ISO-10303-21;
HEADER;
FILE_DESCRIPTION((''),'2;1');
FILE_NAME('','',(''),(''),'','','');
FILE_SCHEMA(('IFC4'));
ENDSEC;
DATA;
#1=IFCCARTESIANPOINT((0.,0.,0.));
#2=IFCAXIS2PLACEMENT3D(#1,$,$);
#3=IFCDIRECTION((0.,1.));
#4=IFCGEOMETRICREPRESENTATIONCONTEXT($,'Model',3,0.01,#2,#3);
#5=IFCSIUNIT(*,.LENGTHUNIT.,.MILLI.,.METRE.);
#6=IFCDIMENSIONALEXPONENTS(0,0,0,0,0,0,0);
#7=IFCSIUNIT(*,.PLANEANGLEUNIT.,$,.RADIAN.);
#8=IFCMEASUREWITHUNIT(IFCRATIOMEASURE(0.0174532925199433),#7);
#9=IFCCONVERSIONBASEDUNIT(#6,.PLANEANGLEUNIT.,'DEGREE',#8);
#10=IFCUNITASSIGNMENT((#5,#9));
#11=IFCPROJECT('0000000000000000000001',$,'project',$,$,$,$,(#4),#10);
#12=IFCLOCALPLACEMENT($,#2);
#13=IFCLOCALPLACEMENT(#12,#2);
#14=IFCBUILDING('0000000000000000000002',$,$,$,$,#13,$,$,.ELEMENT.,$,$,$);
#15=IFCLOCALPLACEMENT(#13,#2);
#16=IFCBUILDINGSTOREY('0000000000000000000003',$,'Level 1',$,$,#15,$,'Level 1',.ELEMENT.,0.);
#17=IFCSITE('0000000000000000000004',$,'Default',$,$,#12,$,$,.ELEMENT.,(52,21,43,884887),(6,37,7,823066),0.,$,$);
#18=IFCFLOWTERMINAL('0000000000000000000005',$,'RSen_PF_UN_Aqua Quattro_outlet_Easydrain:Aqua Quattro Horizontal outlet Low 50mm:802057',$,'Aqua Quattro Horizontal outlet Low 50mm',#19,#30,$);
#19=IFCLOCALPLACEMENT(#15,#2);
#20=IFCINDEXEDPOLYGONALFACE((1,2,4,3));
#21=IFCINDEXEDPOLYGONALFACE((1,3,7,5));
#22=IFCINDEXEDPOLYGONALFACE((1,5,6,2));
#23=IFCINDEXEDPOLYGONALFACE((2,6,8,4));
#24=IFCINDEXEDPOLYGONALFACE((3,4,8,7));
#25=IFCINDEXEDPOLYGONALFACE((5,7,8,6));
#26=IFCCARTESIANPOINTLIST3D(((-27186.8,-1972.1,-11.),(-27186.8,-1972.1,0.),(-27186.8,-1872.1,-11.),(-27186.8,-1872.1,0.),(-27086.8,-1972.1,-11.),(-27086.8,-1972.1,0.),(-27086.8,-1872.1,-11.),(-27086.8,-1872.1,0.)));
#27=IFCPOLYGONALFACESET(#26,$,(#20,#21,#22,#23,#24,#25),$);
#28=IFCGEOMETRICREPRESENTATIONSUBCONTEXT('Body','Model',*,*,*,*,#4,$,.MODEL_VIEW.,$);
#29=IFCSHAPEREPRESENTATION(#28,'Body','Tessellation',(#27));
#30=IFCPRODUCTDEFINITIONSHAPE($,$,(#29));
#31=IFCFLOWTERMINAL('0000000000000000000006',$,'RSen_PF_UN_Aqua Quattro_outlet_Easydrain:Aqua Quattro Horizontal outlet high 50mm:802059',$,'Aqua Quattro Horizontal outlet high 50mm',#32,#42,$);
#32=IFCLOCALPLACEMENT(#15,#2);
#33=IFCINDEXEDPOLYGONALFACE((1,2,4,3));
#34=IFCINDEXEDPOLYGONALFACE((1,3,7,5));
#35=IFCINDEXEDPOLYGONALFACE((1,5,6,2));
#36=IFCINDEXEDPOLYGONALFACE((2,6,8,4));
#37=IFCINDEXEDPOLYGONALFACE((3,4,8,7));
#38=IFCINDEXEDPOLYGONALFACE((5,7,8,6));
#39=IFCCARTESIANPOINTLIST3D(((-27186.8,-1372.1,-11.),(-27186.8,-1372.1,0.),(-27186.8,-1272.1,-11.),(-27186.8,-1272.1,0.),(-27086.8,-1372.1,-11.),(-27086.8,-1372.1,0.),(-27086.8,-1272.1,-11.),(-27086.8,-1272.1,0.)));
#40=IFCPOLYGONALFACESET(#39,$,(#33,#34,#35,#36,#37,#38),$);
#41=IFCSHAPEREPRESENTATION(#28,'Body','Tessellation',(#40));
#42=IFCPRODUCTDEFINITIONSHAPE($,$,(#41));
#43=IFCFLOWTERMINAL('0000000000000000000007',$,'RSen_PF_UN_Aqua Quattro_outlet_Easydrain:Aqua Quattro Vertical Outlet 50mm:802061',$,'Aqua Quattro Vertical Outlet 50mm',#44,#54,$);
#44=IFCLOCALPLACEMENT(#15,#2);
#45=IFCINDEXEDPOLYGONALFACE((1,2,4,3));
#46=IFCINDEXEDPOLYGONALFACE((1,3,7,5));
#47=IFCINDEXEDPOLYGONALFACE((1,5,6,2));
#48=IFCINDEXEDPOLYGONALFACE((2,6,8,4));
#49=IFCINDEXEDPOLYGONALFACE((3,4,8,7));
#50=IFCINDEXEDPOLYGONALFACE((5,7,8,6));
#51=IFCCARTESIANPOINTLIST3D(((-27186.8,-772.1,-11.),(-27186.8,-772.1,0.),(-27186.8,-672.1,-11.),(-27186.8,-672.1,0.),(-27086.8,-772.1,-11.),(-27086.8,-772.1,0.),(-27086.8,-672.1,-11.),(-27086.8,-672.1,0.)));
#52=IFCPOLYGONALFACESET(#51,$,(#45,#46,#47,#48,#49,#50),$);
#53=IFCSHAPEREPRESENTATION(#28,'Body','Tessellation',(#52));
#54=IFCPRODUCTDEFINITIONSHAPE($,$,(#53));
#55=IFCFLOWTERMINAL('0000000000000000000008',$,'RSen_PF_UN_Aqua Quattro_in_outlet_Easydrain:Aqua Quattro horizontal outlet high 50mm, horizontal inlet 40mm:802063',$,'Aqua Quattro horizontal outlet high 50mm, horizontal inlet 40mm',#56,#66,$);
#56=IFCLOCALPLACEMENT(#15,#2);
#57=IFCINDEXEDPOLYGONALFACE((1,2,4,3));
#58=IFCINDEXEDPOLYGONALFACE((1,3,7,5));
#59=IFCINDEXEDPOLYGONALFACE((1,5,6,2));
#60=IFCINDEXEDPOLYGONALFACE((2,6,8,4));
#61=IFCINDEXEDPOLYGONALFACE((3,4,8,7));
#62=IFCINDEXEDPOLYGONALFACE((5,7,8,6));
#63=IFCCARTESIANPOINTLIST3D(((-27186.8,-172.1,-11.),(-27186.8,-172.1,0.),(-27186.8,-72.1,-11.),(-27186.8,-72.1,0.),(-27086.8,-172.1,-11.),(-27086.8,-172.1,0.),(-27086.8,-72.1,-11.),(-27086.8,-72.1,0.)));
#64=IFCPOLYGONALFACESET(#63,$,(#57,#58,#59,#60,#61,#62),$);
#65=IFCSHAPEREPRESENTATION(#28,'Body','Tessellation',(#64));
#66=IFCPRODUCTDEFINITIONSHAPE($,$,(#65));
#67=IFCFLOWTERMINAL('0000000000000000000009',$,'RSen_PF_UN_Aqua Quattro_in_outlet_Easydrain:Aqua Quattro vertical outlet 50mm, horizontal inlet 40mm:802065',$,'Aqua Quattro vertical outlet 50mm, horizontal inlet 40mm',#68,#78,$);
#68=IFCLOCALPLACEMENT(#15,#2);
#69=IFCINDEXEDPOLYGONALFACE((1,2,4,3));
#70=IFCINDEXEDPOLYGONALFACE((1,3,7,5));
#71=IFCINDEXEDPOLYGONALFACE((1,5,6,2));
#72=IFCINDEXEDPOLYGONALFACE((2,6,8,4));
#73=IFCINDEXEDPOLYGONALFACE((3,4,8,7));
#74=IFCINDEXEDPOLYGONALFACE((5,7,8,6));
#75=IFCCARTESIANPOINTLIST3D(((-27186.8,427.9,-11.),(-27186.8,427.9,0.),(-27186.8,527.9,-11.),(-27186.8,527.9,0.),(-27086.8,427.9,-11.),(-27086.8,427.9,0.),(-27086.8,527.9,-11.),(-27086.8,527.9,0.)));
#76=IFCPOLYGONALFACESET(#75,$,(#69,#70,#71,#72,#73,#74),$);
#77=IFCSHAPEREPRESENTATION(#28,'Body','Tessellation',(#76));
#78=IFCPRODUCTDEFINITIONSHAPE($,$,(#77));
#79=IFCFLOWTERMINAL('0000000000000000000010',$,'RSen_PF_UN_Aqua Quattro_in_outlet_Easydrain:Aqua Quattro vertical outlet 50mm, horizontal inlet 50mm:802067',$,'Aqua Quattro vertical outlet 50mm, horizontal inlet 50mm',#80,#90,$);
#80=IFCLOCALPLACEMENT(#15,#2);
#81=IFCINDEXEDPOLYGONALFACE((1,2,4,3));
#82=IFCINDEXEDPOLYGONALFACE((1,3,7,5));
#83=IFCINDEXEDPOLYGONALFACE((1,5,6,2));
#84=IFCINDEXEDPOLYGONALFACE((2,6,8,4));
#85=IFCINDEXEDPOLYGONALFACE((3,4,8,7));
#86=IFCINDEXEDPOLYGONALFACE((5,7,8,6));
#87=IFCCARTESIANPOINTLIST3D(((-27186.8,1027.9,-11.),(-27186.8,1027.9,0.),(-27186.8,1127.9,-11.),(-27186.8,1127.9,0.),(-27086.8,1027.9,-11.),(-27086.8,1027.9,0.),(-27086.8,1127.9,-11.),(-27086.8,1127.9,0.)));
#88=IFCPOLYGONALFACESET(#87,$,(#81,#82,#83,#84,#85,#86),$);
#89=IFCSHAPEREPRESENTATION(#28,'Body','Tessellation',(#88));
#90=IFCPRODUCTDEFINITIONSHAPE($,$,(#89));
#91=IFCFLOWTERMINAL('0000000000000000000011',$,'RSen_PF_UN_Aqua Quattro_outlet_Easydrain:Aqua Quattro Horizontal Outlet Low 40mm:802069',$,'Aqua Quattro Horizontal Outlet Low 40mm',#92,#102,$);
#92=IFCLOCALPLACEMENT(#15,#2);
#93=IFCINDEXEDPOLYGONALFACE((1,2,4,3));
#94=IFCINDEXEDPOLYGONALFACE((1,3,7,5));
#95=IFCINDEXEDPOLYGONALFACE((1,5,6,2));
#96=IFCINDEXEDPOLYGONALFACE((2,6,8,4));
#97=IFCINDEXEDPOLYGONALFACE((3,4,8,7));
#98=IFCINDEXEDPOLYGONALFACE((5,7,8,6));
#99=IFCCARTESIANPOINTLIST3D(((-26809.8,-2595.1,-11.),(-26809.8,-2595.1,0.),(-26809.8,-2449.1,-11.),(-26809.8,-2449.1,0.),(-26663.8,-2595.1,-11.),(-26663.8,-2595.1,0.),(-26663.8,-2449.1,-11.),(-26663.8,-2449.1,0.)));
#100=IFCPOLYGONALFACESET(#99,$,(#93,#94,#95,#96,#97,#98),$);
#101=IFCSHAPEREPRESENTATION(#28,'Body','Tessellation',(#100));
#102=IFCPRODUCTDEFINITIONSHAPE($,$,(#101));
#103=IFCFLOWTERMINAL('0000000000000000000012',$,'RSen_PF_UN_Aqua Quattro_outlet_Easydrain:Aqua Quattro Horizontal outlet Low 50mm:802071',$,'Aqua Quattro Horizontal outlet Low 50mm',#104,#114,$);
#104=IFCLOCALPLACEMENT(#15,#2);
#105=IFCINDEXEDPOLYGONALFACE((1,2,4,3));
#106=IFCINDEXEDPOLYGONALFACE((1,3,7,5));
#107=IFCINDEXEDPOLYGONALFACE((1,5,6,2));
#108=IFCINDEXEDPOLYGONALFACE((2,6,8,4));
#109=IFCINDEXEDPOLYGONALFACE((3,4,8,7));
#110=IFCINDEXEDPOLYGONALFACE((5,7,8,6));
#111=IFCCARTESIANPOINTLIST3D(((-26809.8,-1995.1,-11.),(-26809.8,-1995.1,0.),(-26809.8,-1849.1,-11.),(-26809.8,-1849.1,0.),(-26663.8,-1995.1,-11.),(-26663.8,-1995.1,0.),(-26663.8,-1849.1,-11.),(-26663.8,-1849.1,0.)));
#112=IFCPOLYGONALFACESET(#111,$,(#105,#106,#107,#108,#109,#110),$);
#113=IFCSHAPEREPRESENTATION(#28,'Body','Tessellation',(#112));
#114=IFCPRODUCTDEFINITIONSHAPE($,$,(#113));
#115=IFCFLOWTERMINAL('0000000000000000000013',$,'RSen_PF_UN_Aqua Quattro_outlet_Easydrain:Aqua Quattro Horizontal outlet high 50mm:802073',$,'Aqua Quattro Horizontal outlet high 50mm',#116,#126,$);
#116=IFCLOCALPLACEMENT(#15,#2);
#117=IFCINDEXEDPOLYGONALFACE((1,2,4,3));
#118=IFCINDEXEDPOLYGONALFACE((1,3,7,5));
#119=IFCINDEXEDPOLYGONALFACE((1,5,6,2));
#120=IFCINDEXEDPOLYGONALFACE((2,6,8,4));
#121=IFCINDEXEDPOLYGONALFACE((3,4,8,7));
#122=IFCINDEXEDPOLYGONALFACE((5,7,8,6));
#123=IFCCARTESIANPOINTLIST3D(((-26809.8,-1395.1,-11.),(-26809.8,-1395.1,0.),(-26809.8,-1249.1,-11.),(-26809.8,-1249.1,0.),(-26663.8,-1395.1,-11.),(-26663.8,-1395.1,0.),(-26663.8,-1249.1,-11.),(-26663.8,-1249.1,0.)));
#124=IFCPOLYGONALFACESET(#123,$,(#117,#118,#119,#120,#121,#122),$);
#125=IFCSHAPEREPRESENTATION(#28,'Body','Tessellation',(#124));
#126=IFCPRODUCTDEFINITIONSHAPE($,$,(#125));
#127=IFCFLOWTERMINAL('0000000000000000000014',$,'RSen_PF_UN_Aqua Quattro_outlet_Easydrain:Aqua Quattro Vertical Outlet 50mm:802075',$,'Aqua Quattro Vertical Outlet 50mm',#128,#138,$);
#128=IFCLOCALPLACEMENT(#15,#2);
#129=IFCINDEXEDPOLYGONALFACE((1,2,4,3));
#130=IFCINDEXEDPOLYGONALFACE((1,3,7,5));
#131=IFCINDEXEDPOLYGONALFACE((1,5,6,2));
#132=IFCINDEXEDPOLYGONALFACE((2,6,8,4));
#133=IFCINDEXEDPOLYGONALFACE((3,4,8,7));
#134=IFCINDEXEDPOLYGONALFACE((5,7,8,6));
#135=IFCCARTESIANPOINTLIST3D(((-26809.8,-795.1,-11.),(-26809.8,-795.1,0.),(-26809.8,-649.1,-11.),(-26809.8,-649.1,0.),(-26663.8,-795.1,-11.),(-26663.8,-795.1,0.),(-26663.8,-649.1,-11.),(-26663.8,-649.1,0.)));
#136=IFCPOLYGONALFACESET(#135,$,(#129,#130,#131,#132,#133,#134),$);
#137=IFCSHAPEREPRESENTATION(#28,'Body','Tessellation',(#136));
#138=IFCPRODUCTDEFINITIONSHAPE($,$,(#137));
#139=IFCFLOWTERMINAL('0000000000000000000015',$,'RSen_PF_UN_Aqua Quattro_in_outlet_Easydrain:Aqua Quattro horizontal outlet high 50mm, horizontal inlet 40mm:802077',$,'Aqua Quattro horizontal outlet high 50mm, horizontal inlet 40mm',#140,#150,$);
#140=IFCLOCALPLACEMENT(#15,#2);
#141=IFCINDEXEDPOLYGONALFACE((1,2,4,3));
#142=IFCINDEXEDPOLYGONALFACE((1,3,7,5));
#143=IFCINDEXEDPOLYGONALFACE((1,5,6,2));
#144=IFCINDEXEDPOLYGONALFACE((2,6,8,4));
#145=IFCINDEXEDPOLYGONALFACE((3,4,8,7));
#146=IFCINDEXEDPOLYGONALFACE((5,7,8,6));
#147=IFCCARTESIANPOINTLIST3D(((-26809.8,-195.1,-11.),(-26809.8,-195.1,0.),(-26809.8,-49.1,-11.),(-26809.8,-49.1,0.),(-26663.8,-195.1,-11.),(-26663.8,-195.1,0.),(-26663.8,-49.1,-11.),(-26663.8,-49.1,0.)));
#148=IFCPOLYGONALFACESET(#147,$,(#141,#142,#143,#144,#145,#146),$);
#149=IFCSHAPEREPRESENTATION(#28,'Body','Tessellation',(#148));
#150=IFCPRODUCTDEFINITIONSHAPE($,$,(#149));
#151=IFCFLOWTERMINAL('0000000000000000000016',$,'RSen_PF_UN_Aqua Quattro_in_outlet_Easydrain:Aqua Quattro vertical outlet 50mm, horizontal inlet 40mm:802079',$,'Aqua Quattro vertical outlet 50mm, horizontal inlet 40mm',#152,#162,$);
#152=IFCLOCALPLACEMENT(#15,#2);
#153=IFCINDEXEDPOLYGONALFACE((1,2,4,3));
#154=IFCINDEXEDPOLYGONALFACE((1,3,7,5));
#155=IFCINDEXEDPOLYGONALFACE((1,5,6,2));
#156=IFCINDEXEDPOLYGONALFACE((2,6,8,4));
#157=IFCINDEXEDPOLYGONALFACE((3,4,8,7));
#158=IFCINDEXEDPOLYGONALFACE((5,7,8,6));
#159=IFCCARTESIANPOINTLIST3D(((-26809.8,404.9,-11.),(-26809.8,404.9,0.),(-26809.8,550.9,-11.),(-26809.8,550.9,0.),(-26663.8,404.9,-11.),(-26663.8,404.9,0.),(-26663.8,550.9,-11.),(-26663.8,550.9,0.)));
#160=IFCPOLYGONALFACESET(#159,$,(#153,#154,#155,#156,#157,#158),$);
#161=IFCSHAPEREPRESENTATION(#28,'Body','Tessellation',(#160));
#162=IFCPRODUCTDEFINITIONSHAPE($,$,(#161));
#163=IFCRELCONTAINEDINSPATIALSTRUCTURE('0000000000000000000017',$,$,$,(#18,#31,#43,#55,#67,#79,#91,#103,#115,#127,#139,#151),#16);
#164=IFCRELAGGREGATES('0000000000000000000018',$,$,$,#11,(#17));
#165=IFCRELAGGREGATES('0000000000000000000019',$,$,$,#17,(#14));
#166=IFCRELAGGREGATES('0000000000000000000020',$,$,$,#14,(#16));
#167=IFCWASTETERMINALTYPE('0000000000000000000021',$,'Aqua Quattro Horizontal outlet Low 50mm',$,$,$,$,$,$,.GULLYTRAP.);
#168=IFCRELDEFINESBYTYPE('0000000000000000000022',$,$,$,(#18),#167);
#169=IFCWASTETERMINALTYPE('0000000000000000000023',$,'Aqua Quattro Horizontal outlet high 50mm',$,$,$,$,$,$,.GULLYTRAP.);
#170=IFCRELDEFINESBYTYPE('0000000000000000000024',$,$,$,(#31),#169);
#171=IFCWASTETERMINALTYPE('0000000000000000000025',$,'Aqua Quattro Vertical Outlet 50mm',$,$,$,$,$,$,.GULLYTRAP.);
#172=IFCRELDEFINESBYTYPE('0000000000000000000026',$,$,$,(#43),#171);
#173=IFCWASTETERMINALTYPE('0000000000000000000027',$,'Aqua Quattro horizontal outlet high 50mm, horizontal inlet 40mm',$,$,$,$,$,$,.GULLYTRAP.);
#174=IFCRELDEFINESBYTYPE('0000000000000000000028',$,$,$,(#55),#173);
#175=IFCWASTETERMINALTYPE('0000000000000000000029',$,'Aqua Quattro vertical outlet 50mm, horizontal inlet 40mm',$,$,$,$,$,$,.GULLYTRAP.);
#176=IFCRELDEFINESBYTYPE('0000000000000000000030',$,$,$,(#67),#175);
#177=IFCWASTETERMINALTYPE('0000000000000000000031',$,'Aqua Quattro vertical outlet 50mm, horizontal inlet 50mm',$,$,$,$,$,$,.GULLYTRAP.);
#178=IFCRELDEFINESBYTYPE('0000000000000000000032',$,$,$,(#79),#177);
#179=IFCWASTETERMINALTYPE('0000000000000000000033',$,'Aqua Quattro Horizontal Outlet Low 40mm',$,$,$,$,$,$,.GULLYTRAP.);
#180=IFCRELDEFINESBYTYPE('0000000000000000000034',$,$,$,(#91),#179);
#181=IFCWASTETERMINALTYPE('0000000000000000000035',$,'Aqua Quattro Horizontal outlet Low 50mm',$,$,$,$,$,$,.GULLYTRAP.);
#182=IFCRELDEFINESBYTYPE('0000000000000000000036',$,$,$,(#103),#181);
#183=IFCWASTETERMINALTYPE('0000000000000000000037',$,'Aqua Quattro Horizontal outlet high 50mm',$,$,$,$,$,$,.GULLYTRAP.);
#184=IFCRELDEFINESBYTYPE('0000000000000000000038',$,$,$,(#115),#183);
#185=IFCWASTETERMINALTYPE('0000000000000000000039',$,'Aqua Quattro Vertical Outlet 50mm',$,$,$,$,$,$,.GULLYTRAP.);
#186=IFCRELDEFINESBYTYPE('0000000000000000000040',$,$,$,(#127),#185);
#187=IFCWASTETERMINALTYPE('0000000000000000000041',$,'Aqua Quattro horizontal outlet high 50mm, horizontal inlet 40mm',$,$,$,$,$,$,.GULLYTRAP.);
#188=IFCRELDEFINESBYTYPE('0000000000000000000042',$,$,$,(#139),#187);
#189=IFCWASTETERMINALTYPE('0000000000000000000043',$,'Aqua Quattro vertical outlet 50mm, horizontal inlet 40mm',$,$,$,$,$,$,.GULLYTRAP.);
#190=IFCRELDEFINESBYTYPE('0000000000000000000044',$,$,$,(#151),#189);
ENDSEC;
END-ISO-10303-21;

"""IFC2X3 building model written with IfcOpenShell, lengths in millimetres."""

from ifc_helpers import new_model, entity, si_unit, converted_unit, direction, frame, origin, origin_2d_with_axis, place, context, subcontext, project, spatial, rectangle, extrude, source, transform, mapped, type_object, type_shapes, element, save


model = new_model("IFC2X3")

# Units and contexts
model_context = context("Model", 3, precision=0.01, world=origin(), true_north=direction((0.0, 1.0)))
body_context = subcontext(model_context, "Body", "Model", "MODEL_VIEW")
ifc_project = project(units=[si_unit("LENGTHUNIT", "METRE", prefix="MILLI"), converted_unit("PLANEANGLEUNIT", "DEGREE", entity("IfcRatioMeasure", 0.0174532925199433), si_unit("PLANEANGLEUNIT", "RADIAN"), dimensions=[0, 0, 0, 0, 0, 0, 0])], contexts=[model_context])

# Site, building, storey
site_placement = place(None, origin())
site = spatial("IfcSite", under=ifc_project, at=site_placement, Name="Default", CompositionType="ELEMENT", RefLatitude=(52, 21, 43, 884887), RefLongitude=(6, 37, 7, 823066), RefElevation=0.0)
building_placement = place(site_placement, origin())
building = spatial("IfcBuilding", under=site, at=building_placement, CompositionType="ELEMENT")
storey_placement = place(building_placement, origin())
storey = spatial("IfcBuildingStorey", under=building, at=storey_placement, Name="Level 1", LongName="Level 1", CompositionType="ELEMENT", Elevation=0.0)

# Flow terminals
waste_terminal_type_1 = type_object("IfcWasteTerminalType", Name="Aqua Quattro Horizontal outlet Low 50mm", PredefinedType="GULLYTRAP")
shared_shape_1 = source(origin(), body_context, "Body", "SweptSolid", [
    extrude(rectangle(XDim=100.0, YDim=100.0, at=origin_2d_with_axis()), frame((0.0, 0.0, -11.0), z_axis=(0.0, 0.0, 1.0), x_axis=(-1.0, 0.0, 0.0)), (0.0, 0.0, 1.0), 11.0),
])
type_shapes(waste_terminal_type_1, [shared_shape_1])
flow_terminal_1_placement = place(storey_placement, frame((-27136.8, -1922.1, 0.0)))
element("IfcFlowTerminal", 1, at=flow_terminal_1_placement, inside=storey, type_object=waste_terminal_type_1, Name="RSen_PF_UN_Aqua Quattro_outlet_Easydrain:Aqua Quattro Horizontal outlet Low 50mm:802057", ObjectType="Aqua Quattro Horizontal outlet Low 50mm", context=body_context, shape_type="MappedRepresentation", body=[
    mapped(shared_shape_1, transform((0.0, 0.0, 0.0), scale=1.0)),
])
waste_terminal_type_2 = type_object("IfcWasteTerminalType", Name="Aqua Quattro Horizontal outlet high 50mm", PredefinedType="GULLYTRAP")
shared_shape_2 = source(origin(), body_context, "Body", "SweptSolid", [
    extrude(rectangle(XDim=100.0, YDim=100.0, at=origin_2d_with_axis()), frame((0.0, 0.0, -11.0), z_axis=(0.0, 0.0, 1.0), x_axis=(-1.0, 0.0, 0.0)), (0.0, 0.0, 1.0), 11.0),
])
type_shapes(waste_terminal_type_2, [shared_shape_2])
flow_terminal_2_placement = place(storey_placement, frame((-27136.8, -1322.1, 0.0)))
element("IfcFlowTerminal", 2, at=flow_terminal_2_placement, inside=storey, type_object=waste_terminal_type_2, Name="RSen_PF_UN_Aqua Quattro_outlet_Easydrain:Aqua Quattro Horizontal outlet high 50mm:802059", ObjectType="Aqua Quattro Horizontal outlet high 50mm", context=body_context, shape_type="MappedRepresentation", body=[
    mapped(shared_shape_2, transform((0.0, 0.0, 0.0), scale=1.0)),
])
waste_terminal_type_3 = type_object("IfcWasteTerminalType", Name="Aqua Quattro Vertical Outlet 50mm", PredefinedType="GULLYTRAP")
shared_shape_3 = source(origin(), body_context, "Body", "SweptSolid", [
    extrude(rectangle(XDim=100.0, YDim=100.0, at=origin_2d_with_axis()), frame((0.0, 0.0, -11.0), z_axis=(0.0, 0.0, 1.0), x_axis=(-1.0, 0.0, 0.0)), (0.0, 0.0, 1.0), 11.0),
])
type_shapes(waste_terminal_type_3, [shared_shape_3])
flow_terminal_3_placement = place(storey_placement, frame((-27136.8, -722.1, 0.0)))
element("IfcFlowTerminal", 3, at=flow_terminal_3_placement, inside=storey, type_object=waste_terminal_type_3, Name="RSen_PF_UN_Aqua Quattro_outlet_Easydrain:Aqua Quattro Vertical Outlet 50mm:802061", ObjectType="Aqua Quattro Vertical Outlet 50mm", context=body_context, shape_type="MappedRepresentation", body=[
    mapped(shared_shape_3, transform((0.0, 0.0, 0.0), scale=1.0)),
])
waste_terminal_type_4 = type_object("IfcWasteTerminalType", Name="Aqua Quattro horizontal outlet high 50mm, horizontal inlet 40mm", PredefinedType="GULLYTRAP")
shared_shape_4 = source(origin(), body_context, "Body", "SweptSolid", [
    extrude(rectangle(XDim=100.0, YDim=100.0, at=origin_2d_with_axis()), frame((0.0, 0.0, -11.0), z_axis=(0.0, 0.0, 1.0), x_axis=(-1.0, 0.0, 0.0)), (0.0, 0.0, 1.0), 11.0),
])
type_shapes(waste_terminal_type_4, [shared_shape_4])
flow_terminal_4_placement = place(storey_placement, frame((-27136.8, -122.1, 0.0)))
element("IfcFlowTerminal", 4, at=flow_terminal_4_placement, inside=storey, type_object=waste_terminal_type_4, Name="RSen_PF_UN_Aqua Quattro_in_outlet_Easydrain:Aqua Quattro horizontal outlet high 50mm, horizontal inlet 40mm:802063", ObjectType="Aqua Quattro horizontal outlet high 50mm, horizontal inlet 40mm", context=body_context, shape_type="MappedRepresentation", body=[
    mapped(shared_shape_4, transform((0.0, 0.0, 0.0), scale=1.0)),
])
waste_terminal_type_5 = type_object("IfcWasteTerminalType", Name="Aqua Quattro vertical outlet 50mm, horizontal inlet 40mm", PredefinedType="GULLYTRAP")
shared_shape_5 = source(origin(), body_context, "Body", "SweptSolid", [
    extrude(rectangle(XDim=100.0, YDim=100.0, at=origin_2d_with_axis()), frame((0.0, 0.0, -11.0), z_axis=(0.0, 0.0, 1.0), x_axis=(-1.0, 0.0, 0.0)), (0.0, 0.0, 1.0), 11.0),
])
type_shapes(waste_terminal_type_5, [shared_shape_5])
flow_terminal_5_placement = place(storey_placement, frame((-27136.8, 477.9, 0.0)))
element("IfcFlowTerminal", 5, at=flow_terminal_5_placement, inside=storey, type_object=waste_terminal_type_5, Name="RSen_PF_UN_Aqua Quattro_in_outlet_Easydrain:Aqua Quattro vertical outlet 50mm, horizontal inlet 40mm:802065", ObjectType="Aqua Quattro vertical outlet 50mm, horizontal inlet 40mm", context=body_context, shape_type="MappedRepresentation", body=[
    mapped(shared_shape_5, transform((0.0, 0.0, 0.0), scale=1.0)),
])
waste_terminal_type_6 = type_object("IfcWasteTerminalType", Name="Aqua Quattro vertical outlet 50mm, horizontal inlet 50mm", PredefinedType="GULLYTRAP")
shared_shape_6 = source(origin(), body_context, "Body", "SweptSolid", [
    extrude(rectangle(XDim=100.0, YDim=100.0, at=origin_2d_with_axis()), frame((0.0, 0.0, -11.0), z_axis=(0.0, 0.0, 1.0), x_axis=(-1.0, 0.0, 0.0)), (0.0, 0.0, 1.0), 11.0),
])
type_shapes(waste_terminal_type_6, [shared_shape_6])
flow_terminal_6_placement = place(storey_placement, frame((-27136.8, 1077.9, 0.0)))
element("IfcFlowTerminal", 6, at=flow_terminal_6_placement, inside=storey, type_object=waste_terminal_type_6, Name="RSen_PF_UN_Aqua Quattro_in_outlet_Easydrain:Aqua Quattro vertical outlet 50mm, horizontal inlet 50mm:802067", ObjectType="Aqua Quattro vertical outlet 50mm, horizontal inlet 50mm", context=body_context, shape_type="MappedRepresentation", body=[
    mapped(shared_shape_6, transform((0.0, 0.0, 0.0), scale=1.0)),
])
waste_terminal_type_7 = type_object("IfcWasteTerminalType", Name="Aqua Quattro Horizontal Outlet Low 40mm", PredefinedType="GULLYTRAP")
shared_shape_7 = source(origin(), body_context, "Body", "SweptSolid", [
    extrude(rectangle(XDim=146.0, YDim=146.0, at=origin_2d_with_axis()), frame((0.0, 0.0, -11.0), z_axis=(0.0, 0.0, 1.0), x_axis=(-1.0, 0.0, 0.0)), (0.0, 0.0, 1.0), 11.0),
])
type_shapes(waste_terminal_type_7, [shared_shape_7])
flow_terminal_7_placement = place(storey_placement, frame((-26736.8, -2522.1, 0.0)))
element("IfcFlowTerminal", 7, at=flow_terminal_7_placement, inside=storey, type_object=waste_terminal_type_7, Name="RSen_PF_UN_Aqua Quattro_outlet_Easydrain:Aqua Quattro Horizontal Outlet Low 40mm:802069", ObjectType="Aqua Quattro Horizontal Outlet Low 40mm", context=body_context, shape_type="MappedRepresentation", body=[
    mapped(shared_shape_7, transform((0.0, 0.0, 0.0), scale=1.0)),
])
waste_terminal_type_8 = type_object("IfcWasteTerminalType", Name="Aqua Quattro Horizontal outlet Low 50mm", PredefinedType="GULLYTRAP")
shared_shape_8 = source(origin(), body_context, "Body", "SweptSolid", [
    extrude(rectangle(XDim=146.0, YDim=146.0, at=origin_2d_with_axis()), frame((0.0, 0.0, -11.0), z_axis=(0.0, 0.0, 1.0), x_axis=(-1.0, 0.0, 0.0)), (0.0, 0.0, 1.0), 11.0),
])
type_shapes(waste_terminal_type_8, [shared_shape_8])
flow_terminal_8_placement = place(storey_placement, frame((-26736.8, -1922.1, 0.0)))
element("IfcFlowTerminal", 8, at=flow_terminal_8_placement, inside=storey, type_object=waste_terminal_type_8, Name="RSen_PF_UN_Aqua Quattro_outlet_Easydrain:Aqua Quattro Horizontal outlet Low 50mm:802071", ObjectType="Aqua Quattro Horizontal outlet Low 50mm", context=body_context, shape_type="MappedRepresentation", body=[
    mapped(shared_shape_8, transform((0.0, 0.0, 0.0), scale=1.0)),
])
waste_terminal_type_9 = type_object("IfcWasteTerminalType", Name="Aqua Quattro Horizontal outlet high 50mm", PredefinedType="GULLYTRAP")
shared_shape_9 = source(origin(), body_context, "Body", "SweptSolid", [
    extrude(rectangle(XDim=146.0, YDim=146.0, at=origin_2d_with_axis()), frame((0.0, 0.0, -11.0), z_axis=(0.0, 0.0, 1.0), x_axis=(-1.0, 0.0, 0.0)), (0.0, 0.0, 1.0), 11.0),
])
type_shapes(waste_terminal_type_9, [shared_shape_9])
flow_terminal_9_placement = place(storey_placement, frame((-26736.8, -1322.1, 0.0)))
element("IfcFlowTerminal", 9, at=flow_terminal_9_placement, inside=storey, type_object=waste_terminal_type_9, Name="RSen_PF_UN_Aqua Quattro_outlet_Easydrain:Aqua Quattro Horizontal outlet high 50mm:802073", ObjectType="Aqua Quattro Horizontal outlet high 50mm", context=body_context, shape_type="MappedRepresentation", body=[
    mapped(shared_shape_9, transform((0.0, 0.0, 0.0), scale=1.0)),
])
waste_terminal_type_10 = type_object("IfcWasteTerminalType", Name="Aqua Quattro Vertical Outlet 50mm", PredefinedType="GULLYTRAP")
shared_shape_10 = source(origin(), body_context, "Body", "SweptSolid", [
    extrude(rectangle(XDim=146.0, YDim=146.0, at=origin_2d_with_axis()), frame((0.0, 0.0, -11.0), z_axis=(0.0, 0.0, 1.0), x_axis=(-1.0, 0.0, 0.0)), (0.0, 0.0, 1.0), 11.0),
])
type_shapes(waste_terminal_type_10, [shared_shape_10])
flow_terminal_10_placement = place(storey_placement, frame((-26736.8, -722.1, 0.0)))
element("IfcFlowTerminal", 10, at=flow_terminal_10_placement, inside=storey, type_object=waste_terminal_type_10, Name="RSen_PF_UN_Aqua Quattro_outlet_Easydrain:Aqua Quattro Vertical Outlet 50mm:802075", ObjectType="Aqua Quattro Vertical Outlet 50mm", context=body_context, shape_type="MappedRepresentation", body=[
    mapped(shared_shape_10, transform((0.0, 0.0, 0.0), scale=1.0)),
])
waste_terminal_type_11 = type_object("IfcWasteTerminalType", Name="Aqua Quattro horizontal outlet high 50mm, horizontal inlet 40mm", PredefinedType="GULLYTRAP")
shared_shape_11 = source(origin(), body_context, "Body", "SweptSolid", [
    extrude(rectangle(XDim=146.0, YDim=146.0, at=origin_2d_with_axis()), frame((0.0, 0.0, -11.0), z_axis=(0.0, 0.0, 1.0), x_axis=(-1.0, 0.0, 0.0)), (0.0, 0.0, 1.0), 11.0),
])
type_shapes(waste_terminal_type_11, [shared_shape_11])
flow_terminal_11_placement = place(storey_placement, frame((-26736.8, -122.1, 0.0)))
element("IfcFlowTerminal", 11, at=flow_terminal_11_placement, inside=storey, type_object=waste_terminal_type_11, Name="RSen_PF_UN_Aqua Quattro_in_outlet_Easydrain:Aqua Quattro horizontal outlet high 50mm, horizontal inlet 40mm:802077", ObjectType="Aqua Quattro horizontal outlet high 50mm, horizontal inlet 40mm", context=body_context, shape_type="MappedRepresentation", body=[
    mapped(shared_shape_11, transform((0.0, 0.0, 0.0), scale=1.0)),
])
waste_terminal_type_12 = type_object("IfcWasteTerminalType", Name="Aqua Quattro vertical outlet 50mm, horizontal inlet 40mm", PredefinedType="GULLYTRAP")
shared_shape_12 = source(origin(), body_context, "Body", "SweptSolid", [
    extrude(rectangle(XDim=146.0, YDim=146.0, at=origin_2d_with_axis()), frame((0.0, 0.0, -11.0), z_axis=(0.0, 0.0, 1.0), x_axis=(-1.0, 0.0, 0.0)), (0.0, 0.0, 1.0), 11.0),
])
type_shapes(waste_terminal_type_12, [shared_shape_12])
flow_terminal_12_placement = place(storey_placement, frame((-26736.8, 477.9, 0.0)))
element("IfcFlowTerminal", 12, at=flow_terminal_12_placement, inside=storey, type_object=waste_terminal_type_12, Name="RSen_PF_UN_Aqua Quattro_in_outlet_Easydrain:Aqua Quattro vertical outlet 50mm, horizontal inlet 40mm:802079", ObjectType="Aqua Quattro vertical outlet 50mm, horizontal inlet 40mm", context=body_context, shape_type="MappedRepresentation", body=[
    mapped(shared_shape_12, transform((0.0, 0.0, 0.0), scale=1.0)),
])

save(model, "model.ifc")
